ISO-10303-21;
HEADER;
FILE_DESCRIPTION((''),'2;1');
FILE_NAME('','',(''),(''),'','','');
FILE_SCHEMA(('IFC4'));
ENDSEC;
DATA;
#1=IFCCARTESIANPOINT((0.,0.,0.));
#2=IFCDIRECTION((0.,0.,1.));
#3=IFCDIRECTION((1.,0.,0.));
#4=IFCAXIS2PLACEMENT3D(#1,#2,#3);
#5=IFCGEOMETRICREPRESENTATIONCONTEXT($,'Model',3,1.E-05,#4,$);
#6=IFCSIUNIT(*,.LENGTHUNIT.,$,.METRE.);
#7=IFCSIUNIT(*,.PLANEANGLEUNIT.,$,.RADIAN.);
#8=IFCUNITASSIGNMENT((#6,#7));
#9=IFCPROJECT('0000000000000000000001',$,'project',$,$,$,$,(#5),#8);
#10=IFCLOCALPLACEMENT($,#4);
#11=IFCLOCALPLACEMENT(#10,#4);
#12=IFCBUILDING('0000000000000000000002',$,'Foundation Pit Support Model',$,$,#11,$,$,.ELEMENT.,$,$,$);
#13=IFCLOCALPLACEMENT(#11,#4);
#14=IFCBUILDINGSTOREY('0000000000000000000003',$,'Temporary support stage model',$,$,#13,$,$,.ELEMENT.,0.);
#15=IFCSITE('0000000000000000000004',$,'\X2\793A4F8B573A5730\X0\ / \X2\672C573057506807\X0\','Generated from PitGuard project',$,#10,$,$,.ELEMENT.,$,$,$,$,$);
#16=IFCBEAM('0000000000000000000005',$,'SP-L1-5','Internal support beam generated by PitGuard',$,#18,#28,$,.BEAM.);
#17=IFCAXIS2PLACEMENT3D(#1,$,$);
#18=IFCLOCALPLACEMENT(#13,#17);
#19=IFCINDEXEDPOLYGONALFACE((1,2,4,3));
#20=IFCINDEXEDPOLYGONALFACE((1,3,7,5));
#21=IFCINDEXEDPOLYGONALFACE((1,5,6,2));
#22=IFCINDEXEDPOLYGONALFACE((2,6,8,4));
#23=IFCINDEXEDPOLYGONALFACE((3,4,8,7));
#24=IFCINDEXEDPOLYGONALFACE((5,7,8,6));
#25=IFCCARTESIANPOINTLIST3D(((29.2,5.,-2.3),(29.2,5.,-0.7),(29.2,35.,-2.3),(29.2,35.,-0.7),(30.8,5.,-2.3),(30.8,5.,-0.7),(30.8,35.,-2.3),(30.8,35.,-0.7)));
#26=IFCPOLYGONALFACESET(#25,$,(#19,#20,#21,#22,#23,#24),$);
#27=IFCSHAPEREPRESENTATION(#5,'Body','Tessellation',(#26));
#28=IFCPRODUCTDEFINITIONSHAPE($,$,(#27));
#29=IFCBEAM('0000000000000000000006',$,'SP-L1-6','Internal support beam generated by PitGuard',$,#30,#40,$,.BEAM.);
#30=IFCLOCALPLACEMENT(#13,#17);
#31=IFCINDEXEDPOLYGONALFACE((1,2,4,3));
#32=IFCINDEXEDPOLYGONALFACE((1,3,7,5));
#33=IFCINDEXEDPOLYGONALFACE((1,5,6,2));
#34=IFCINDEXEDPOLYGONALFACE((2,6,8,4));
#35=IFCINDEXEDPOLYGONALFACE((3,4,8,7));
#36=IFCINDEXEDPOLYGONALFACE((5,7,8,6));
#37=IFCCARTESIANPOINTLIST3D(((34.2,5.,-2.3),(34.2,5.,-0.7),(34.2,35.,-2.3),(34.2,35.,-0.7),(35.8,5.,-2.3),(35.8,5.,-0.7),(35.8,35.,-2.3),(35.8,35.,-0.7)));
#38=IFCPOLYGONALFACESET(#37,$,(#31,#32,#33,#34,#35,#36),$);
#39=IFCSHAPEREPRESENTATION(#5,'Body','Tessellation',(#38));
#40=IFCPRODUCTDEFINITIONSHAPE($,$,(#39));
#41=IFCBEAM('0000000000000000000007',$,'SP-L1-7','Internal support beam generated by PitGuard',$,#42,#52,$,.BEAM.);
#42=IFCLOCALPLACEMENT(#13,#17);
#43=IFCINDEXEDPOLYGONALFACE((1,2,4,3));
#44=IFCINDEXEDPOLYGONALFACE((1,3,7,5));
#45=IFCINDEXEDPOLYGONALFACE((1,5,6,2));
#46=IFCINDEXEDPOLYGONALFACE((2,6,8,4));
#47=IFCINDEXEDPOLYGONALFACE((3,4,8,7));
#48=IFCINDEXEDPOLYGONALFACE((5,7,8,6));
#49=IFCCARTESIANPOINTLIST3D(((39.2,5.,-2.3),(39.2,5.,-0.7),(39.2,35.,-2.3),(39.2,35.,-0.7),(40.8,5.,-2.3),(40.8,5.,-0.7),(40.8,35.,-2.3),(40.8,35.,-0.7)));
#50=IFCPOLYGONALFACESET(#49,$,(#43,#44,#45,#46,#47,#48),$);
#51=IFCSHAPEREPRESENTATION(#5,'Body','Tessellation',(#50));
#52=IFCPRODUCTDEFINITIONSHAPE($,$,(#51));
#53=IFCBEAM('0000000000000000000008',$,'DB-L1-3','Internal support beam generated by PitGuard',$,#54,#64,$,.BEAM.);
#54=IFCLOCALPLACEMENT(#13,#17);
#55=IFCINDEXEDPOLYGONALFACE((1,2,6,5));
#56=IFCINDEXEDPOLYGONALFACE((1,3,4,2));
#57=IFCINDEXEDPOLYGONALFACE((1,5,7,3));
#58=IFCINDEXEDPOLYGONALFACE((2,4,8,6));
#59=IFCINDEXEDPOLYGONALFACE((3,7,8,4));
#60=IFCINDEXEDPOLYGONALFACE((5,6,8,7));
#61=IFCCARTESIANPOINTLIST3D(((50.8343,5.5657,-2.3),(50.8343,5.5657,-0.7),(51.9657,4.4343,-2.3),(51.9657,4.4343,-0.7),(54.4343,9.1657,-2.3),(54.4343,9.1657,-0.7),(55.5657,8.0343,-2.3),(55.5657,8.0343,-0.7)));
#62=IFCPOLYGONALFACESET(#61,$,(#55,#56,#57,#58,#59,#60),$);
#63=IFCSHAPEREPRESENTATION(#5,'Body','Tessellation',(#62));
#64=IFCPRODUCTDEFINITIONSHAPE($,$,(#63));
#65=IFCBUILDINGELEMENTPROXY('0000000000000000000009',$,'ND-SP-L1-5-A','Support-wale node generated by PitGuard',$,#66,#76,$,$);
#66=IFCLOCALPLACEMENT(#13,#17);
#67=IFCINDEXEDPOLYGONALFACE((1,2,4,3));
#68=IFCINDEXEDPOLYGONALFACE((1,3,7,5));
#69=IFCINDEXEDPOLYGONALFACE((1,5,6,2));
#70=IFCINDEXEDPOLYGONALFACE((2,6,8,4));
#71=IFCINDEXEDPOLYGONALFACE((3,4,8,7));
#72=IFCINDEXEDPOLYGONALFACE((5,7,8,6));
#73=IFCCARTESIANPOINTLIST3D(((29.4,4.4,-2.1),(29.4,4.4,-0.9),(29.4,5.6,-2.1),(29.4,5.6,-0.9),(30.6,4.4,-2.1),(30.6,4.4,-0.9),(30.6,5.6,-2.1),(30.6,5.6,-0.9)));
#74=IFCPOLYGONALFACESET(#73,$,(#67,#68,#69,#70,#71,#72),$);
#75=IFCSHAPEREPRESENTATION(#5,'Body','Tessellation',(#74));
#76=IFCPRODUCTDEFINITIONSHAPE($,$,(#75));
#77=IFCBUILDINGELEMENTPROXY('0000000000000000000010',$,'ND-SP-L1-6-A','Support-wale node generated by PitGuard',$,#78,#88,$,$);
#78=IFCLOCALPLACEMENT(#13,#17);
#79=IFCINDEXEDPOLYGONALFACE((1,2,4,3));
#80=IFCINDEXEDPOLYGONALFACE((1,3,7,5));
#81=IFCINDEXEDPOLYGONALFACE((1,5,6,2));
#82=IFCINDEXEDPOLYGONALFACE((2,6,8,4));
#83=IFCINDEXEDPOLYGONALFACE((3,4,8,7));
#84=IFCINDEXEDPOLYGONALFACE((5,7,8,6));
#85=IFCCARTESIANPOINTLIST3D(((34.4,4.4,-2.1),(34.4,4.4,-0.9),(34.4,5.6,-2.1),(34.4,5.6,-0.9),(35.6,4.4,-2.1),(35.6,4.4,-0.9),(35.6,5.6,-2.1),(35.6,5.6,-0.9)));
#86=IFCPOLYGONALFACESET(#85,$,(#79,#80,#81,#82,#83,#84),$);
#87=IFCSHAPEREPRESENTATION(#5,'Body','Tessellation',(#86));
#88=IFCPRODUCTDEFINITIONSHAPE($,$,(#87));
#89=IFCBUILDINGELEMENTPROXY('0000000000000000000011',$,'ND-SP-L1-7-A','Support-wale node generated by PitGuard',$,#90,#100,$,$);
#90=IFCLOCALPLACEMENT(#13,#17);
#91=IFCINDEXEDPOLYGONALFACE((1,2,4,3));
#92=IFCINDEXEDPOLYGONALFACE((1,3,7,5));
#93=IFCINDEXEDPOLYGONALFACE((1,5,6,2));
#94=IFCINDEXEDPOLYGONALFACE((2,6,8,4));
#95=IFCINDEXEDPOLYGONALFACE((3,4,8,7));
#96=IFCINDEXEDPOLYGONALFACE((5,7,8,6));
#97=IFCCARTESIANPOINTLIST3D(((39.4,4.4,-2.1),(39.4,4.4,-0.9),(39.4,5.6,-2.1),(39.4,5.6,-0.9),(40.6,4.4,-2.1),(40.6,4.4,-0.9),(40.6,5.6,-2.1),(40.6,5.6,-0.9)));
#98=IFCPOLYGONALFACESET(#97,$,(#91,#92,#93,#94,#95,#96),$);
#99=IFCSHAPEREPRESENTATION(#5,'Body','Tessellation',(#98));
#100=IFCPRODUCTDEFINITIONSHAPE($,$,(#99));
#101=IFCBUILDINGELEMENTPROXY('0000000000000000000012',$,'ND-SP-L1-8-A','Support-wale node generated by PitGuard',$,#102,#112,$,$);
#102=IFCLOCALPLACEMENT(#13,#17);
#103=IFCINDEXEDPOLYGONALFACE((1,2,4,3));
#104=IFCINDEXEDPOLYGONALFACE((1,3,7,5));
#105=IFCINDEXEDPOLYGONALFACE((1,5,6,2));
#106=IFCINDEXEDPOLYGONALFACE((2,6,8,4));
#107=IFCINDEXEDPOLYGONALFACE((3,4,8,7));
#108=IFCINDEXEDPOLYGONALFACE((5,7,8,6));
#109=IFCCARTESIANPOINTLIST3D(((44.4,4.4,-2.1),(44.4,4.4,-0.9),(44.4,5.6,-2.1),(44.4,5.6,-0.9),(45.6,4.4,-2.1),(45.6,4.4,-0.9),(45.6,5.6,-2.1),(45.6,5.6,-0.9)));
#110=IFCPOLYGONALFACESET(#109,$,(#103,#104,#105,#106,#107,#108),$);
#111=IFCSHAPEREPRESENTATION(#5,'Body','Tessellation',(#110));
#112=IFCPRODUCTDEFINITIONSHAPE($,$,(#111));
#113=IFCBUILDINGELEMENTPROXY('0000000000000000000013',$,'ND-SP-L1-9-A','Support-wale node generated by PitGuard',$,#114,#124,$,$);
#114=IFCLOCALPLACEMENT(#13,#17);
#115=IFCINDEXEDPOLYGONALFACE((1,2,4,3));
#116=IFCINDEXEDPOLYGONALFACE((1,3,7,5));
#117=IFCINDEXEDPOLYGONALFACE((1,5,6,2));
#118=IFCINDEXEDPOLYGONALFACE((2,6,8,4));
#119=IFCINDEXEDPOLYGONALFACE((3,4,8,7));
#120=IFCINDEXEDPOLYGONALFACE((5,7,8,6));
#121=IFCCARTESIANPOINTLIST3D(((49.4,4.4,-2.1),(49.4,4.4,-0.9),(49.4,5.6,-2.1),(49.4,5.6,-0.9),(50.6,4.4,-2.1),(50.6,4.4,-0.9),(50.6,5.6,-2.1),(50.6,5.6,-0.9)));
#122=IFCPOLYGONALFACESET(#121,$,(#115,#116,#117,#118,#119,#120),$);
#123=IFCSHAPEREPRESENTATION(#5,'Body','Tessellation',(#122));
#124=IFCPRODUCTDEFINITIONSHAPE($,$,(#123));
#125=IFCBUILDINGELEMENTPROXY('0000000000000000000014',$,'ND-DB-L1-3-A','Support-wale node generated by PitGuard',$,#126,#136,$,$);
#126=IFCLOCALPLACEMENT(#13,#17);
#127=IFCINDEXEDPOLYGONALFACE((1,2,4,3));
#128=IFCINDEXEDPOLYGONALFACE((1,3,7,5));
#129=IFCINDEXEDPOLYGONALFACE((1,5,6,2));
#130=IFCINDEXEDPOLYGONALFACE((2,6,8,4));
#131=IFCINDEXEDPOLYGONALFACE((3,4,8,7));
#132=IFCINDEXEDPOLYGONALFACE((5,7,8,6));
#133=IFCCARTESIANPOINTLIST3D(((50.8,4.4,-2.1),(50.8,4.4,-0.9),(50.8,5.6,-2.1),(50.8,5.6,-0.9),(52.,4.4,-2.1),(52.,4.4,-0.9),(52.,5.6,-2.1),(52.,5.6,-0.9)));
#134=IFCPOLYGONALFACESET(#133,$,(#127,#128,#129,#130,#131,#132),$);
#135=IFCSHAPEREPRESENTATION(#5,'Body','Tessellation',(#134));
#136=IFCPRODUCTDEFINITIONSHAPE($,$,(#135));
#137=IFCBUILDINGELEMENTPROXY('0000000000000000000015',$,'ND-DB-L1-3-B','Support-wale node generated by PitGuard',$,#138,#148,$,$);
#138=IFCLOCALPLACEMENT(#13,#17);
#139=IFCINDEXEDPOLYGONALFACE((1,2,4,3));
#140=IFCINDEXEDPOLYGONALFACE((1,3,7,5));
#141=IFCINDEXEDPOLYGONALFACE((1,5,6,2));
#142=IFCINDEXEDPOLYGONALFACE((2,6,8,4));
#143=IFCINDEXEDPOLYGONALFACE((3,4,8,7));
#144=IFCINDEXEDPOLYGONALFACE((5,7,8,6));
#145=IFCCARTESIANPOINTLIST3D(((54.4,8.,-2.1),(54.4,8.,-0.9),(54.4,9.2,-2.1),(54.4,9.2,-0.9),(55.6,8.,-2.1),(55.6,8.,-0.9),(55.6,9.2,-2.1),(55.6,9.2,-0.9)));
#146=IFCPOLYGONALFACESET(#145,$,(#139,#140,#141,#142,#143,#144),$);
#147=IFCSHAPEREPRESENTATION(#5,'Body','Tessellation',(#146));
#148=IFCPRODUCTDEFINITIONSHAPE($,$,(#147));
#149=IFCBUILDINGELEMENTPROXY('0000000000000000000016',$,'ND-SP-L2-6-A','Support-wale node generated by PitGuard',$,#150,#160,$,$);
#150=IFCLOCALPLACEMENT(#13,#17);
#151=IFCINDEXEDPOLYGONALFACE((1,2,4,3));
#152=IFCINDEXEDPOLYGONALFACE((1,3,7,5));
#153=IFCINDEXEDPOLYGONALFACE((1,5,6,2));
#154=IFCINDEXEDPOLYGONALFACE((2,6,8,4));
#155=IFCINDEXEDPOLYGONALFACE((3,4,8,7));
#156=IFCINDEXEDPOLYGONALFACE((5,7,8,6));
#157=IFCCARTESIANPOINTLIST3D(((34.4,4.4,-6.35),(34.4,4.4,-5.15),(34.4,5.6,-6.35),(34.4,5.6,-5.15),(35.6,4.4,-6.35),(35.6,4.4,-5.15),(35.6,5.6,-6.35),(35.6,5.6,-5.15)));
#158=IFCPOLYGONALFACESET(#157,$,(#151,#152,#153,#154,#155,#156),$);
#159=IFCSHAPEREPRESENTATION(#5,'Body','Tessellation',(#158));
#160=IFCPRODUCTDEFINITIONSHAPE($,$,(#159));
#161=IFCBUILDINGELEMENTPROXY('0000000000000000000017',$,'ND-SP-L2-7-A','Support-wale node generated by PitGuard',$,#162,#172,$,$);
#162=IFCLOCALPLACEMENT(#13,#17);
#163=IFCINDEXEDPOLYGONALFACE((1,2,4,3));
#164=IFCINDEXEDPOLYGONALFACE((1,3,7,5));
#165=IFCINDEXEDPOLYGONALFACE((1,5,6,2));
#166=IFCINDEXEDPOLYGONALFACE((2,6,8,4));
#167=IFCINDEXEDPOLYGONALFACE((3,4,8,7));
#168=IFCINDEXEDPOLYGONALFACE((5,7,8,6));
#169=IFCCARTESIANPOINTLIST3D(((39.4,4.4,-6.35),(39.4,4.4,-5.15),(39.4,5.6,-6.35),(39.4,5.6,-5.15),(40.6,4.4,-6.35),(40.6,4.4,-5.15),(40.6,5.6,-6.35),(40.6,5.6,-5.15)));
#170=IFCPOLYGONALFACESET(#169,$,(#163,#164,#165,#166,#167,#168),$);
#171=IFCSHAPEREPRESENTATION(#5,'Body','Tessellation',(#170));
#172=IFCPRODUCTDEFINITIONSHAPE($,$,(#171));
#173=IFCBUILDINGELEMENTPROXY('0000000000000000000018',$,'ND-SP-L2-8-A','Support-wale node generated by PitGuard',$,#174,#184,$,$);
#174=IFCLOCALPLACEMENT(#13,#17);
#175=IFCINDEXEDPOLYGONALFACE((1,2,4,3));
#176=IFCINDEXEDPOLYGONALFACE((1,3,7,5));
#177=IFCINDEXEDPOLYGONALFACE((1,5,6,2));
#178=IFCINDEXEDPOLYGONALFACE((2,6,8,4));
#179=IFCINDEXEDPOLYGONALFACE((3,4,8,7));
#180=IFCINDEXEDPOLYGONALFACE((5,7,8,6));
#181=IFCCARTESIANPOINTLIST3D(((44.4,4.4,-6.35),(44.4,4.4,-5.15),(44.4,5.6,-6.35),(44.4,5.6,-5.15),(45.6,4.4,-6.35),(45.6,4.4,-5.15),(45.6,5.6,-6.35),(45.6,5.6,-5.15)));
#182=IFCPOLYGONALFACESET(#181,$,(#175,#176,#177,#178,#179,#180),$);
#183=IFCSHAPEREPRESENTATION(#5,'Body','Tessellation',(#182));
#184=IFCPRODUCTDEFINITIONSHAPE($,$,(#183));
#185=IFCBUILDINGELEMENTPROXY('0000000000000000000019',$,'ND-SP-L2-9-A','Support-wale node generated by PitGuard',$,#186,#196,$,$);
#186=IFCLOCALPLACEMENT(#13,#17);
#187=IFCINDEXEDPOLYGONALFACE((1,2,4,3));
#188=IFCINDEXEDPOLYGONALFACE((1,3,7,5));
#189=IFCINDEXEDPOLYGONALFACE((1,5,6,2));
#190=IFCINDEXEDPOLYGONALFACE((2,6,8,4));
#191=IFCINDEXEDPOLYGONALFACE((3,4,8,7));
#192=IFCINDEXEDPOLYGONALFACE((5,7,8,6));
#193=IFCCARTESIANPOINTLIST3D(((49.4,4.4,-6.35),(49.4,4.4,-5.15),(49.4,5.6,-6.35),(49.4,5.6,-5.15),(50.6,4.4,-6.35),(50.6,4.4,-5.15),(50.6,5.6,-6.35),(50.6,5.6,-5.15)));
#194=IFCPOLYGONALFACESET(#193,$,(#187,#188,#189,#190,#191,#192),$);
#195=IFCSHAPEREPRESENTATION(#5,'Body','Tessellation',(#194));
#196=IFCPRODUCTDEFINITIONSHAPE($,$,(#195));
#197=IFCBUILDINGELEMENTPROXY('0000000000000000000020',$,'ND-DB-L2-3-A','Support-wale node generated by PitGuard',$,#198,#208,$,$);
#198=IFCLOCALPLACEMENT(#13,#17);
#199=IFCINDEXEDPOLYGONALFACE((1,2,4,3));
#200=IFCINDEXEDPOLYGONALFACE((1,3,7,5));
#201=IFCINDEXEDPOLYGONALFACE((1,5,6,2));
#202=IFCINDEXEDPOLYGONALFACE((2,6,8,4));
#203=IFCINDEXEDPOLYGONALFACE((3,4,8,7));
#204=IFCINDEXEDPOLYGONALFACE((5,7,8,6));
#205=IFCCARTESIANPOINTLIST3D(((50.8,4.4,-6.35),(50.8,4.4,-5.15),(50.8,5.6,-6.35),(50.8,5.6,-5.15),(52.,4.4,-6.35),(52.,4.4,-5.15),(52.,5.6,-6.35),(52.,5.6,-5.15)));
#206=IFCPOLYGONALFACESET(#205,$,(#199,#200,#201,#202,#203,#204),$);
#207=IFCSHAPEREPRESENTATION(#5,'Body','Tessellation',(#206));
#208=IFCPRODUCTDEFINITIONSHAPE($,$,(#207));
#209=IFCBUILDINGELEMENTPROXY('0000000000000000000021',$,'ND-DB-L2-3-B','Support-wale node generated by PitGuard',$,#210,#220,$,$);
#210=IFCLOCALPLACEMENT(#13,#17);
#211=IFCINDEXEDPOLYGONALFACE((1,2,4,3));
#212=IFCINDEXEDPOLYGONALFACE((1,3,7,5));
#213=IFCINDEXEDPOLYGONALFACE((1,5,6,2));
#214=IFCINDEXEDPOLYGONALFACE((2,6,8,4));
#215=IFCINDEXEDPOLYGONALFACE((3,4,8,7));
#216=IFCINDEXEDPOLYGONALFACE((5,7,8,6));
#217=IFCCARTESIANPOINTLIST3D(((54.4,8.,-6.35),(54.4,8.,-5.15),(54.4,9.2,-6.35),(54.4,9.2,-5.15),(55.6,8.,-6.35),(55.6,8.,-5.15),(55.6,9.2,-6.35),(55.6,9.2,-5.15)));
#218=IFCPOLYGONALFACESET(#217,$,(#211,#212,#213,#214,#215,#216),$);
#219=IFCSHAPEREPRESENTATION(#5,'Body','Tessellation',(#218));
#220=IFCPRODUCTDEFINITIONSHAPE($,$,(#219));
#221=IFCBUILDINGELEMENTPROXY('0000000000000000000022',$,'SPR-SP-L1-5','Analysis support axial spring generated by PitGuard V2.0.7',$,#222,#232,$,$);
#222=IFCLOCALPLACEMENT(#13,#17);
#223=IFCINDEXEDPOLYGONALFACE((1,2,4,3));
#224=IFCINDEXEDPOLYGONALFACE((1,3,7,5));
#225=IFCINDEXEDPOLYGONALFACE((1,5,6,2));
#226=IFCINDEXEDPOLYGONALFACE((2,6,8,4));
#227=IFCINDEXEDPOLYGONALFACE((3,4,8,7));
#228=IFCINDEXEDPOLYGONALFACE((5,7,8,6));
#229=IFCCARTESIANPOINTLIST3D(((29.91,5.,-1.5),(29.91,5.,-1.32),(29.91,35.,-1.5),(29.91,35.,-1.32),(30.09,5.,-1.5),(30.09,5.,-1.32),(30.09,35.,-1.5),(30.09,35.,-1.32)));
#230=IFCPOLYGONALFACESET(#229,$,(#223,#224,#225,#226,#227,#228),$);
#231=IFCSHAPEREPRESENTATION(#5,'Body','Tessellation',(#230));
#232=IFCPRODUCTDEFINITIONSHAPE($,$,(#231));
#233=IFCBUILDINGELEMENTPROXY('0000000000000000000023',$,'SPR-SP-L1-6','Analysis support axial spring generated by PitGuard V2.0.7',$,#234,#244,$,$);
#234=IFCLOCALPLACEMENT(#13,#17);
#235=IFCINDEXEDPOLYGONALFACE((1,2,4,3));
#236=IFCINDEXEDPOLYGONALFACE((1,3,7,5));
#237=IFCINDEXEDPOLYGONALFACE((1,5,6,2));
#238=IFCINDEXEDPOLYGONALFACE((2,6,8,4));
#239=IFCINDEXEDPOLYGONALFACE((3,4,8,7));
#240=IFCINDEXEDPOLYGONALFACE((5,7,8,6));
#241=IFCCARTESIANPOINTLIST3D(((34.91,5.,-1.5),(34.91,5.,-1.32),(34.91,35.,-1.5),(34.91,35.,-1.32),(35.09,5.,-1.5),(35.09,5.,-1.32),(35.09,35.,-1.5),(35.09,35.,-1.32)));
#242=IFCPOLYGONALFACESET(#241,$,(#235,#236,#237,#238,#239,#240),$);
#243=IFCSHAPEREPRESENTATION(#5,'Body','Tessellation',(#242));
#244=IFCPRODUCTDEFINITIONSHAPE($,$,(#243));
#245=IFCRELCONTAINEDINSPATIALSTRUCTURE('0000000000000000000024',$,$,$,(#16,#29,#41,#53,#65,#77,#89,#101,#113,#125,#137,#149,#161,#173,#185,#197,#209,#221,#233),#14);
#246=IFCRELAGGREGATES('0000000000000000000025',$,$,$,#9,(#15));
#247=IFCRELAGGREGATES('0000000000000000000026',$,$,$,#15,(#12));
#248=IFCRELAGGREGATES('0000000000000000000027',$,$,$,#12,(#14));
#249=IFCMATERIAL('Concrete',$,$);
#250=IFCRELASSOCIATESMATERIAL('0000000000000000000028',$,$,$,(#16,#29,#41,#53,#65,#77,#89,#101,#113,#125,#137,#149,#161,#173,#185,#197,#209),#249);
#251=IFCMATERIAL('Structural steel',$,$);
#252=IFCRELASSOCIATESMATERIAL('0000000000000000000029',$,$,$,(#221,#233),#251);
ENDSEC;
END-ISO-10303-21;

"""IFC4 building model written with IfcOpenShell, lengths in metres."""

from ifc_helpers import new_model, si_unit, frame, origin_with_axes, origin_2d, place, context, project, spatial, rectangle, extrude, material, element, save


model = new_model("IFC4")

# Units and contexts
model_context = context("Model", 3, precision=1e-05, world=origin_with_axes())
ifc_project = project(units=[si_unit("LENGTHUNIT", "METRE"), si_unit("PLANEANGLEUNIT", "RADIAN")], contexts=[model_context])

# Site, building, storey
site_placement = place(None, origin_with_axes())
site = spatial("IfcSite", under=ifc_project, at=site_placement, Name="示例场地 / 本地坐标", Description="Generated from PitGuard project", CompositionType="ELEMENT")
building_placement = place(site_placement, origin_with_axes())
building = spatial("IfcBuilding", under=site, at=building_placement, Name="Foundation Pit Support Model", CompositionType="ELEMENT")
storey_placement = place(building_placement, origin_with_axes())
storey = spatial("IfcBuildingStorey", under=building, at=storey_placement, Name="Temporary support stage model", CompositionType="ELEMENT", Elevation=0.0)

# Beams
ifc_material_1 = material(Name="Concrete")
for number, where, z_axis, x_axis, name in (
    (1, (30.0, 20.0, -2.3), (0.0, 0.0, 1.0), (0.0, 1.0, 0.0), "SP-L1-5"),
    (2, (35.0, 20.0, -2.3), (0.0, 0.0, 1.0), (0.0, 1.0, 0.0), "SP-L1-6"),
    (3, (40.0, 20.0, -2.3), (0.0, 0.0, 1.0), (0.0, 1.0, 0.0), "SP-L1-7"),
):
    element("IfcBeam", number, at=place(storey_placement, frame(where, z_axis=z_axis, x_axis=x_axis)), inside=storey, material=ifc_material_1, Name=name, Description="Internal support beam generated by PitGuard", PredefinedType="BEAM", context=model_context, shape_type="SweptSolid", body=[
        extrude(rectangle(XDim=30.0, YDim=1.6, at=origin_2d()), origin_with_axes(), (0.0, 0.0, 1.0), 1.6),
    ])
beam_placement = place(storey_placement, frame((53.2, 6.8, -2.3), z_axis=(0.0, 0.0, 1.0), x_axis=(0.707107, 0.707107, 0.0)))
element("IfcBeam", 4, at=beam_placement, inside=storey, material=ifc_material_1, Name="DB-L1-3", Description="Internal support beam generated by PitGuard", PredefinedType="BEAM", context=model_context, shape_type="SweptSolid", body=[
    extrude(rectangle(XDim=5.0912, YDim=1.6, at=origin_2d()), origin_with_axes(), (0.0, 0.0, 1.0), 1.6),
])

# Building element proxies
for number, where, z_axis, x_axis, name in (
    (5, (30.0, 5.0, -2.1), (0.0, 0.0, 1.0), (1.0, 0.0, 0.0), "ND-SP-L1-5-A"),
    (6, (35.0, 5.0, -2.1), (0.0, 0.0, 1.0), (1.0, 0.0, 0.0), "ND-SP-L1-6-A"),
    (7, (40.0, 5.0, -2.1), (0.0, 0.0, 1.0), (1.0, 0.0, 0.0), "ND-SP-L1-7-A"),
    (8, (45.0, 5.0, -2.1), (0.0, 0.0, 1.0), (1.0, 0.0, 0.0), "ND-SP-L1-8-A"),
    (9, (50.0, 5.0, -2.1), (0.0, 0.0, 1.0), (1.0, 0.0, 0.0), "ND-SP-L1-9-A"),
    (10, (51.4, 5.0, -2.1), (0.0, 0.0, 1.0), (1.0, 0.0, 0.0), "ND-DB-L1-3-A"),
    (11, (55.0, 8.6, -2.1), (0.0, 0.0, 1.0), (1.0, 0.0, 0.0), "ND-DB-L1-3-B"),
    (12, (35.0, 5.0, -6.35), (0.0, 0.0, 1.0), (1.0, 0.0, 0.0), "ND-SP-L2-6-A"),
    (13, (40.0, 5.0, -6.35), (0.0, 0.0, 1.0), (1.0, 0.0, 0.0), "ND-SP-L2-7-A"),
    (14, (45.0, 5.0, -6.35), (0.0, 0.0, 1.0), (1.0, 0.0, 0.0), "ND-SP-L2-8-A"),
    (15, (50.0, 5.0, -6.35), (0.0, 0.0, 1.0), (1.0, 0.0, 0.0), "ND-SP-L2-9-A"),
    (16, (51.4, 5.0, -6.35), (0.0, 0.0, 1.0), (1.0, 0.0, 0.0), "ND-DB-L2-3-A"),
    (17, (55.0, 8.6, -6.35), (0.0, 0.0, 1.0), (1.0, 0.0, 0.0), "ND-DB-L2-3-B"),
):
    element("IfcBuildingElementProxy", number, at=place(storey_placement, frame(where, z_axis=z_axis, x_axis=x_axis)), inside=storey, material=ifc_material_1, Name=name, Description="Support-wale node generated by PitGuard", context=model_context, shape_type="SweptSolid", body=[
        extrude(rectangle(XDim=1.2, YDim=1.2, at=origin_2d()), origin_with_axes(), (0.0, 0.0, 1.0), 1.2),
    ])
ifc_material_2 = material(Name="Structural steel")
for number, where, z_axis, x_axis, name in (
    (18, (30.0, 20.0, -1.5), (0.0, 0.0, 1.0), (0.0, 1.0, 0.0), "SPR-SP-L1-5"),
    (19, (35.0, 20.0, -1.5), (0.0, 0.0, 1.0), (0.0, 1.0, 0.0), "SPR-SP-L1-6"),
):
    element("IfcBuildingElementProxy", number, at=place(storey_placement, frame(where, z_axis=z_axis, x_axis=x_axis)), inside=storey, material=ifc_material_2, Name=name, Description="Analysis support axial spring generated by PitGuard V2.0.7", context=model_context, shape_type="SweptSolid", body=[
        extrude(rectangle(XDim=30.0, YDim=0.18, at=origin_2d()), origin_with_axes(), (0.0, 0.0, 1.0), 0.18),
    ])

save(model, "model.ifc")
